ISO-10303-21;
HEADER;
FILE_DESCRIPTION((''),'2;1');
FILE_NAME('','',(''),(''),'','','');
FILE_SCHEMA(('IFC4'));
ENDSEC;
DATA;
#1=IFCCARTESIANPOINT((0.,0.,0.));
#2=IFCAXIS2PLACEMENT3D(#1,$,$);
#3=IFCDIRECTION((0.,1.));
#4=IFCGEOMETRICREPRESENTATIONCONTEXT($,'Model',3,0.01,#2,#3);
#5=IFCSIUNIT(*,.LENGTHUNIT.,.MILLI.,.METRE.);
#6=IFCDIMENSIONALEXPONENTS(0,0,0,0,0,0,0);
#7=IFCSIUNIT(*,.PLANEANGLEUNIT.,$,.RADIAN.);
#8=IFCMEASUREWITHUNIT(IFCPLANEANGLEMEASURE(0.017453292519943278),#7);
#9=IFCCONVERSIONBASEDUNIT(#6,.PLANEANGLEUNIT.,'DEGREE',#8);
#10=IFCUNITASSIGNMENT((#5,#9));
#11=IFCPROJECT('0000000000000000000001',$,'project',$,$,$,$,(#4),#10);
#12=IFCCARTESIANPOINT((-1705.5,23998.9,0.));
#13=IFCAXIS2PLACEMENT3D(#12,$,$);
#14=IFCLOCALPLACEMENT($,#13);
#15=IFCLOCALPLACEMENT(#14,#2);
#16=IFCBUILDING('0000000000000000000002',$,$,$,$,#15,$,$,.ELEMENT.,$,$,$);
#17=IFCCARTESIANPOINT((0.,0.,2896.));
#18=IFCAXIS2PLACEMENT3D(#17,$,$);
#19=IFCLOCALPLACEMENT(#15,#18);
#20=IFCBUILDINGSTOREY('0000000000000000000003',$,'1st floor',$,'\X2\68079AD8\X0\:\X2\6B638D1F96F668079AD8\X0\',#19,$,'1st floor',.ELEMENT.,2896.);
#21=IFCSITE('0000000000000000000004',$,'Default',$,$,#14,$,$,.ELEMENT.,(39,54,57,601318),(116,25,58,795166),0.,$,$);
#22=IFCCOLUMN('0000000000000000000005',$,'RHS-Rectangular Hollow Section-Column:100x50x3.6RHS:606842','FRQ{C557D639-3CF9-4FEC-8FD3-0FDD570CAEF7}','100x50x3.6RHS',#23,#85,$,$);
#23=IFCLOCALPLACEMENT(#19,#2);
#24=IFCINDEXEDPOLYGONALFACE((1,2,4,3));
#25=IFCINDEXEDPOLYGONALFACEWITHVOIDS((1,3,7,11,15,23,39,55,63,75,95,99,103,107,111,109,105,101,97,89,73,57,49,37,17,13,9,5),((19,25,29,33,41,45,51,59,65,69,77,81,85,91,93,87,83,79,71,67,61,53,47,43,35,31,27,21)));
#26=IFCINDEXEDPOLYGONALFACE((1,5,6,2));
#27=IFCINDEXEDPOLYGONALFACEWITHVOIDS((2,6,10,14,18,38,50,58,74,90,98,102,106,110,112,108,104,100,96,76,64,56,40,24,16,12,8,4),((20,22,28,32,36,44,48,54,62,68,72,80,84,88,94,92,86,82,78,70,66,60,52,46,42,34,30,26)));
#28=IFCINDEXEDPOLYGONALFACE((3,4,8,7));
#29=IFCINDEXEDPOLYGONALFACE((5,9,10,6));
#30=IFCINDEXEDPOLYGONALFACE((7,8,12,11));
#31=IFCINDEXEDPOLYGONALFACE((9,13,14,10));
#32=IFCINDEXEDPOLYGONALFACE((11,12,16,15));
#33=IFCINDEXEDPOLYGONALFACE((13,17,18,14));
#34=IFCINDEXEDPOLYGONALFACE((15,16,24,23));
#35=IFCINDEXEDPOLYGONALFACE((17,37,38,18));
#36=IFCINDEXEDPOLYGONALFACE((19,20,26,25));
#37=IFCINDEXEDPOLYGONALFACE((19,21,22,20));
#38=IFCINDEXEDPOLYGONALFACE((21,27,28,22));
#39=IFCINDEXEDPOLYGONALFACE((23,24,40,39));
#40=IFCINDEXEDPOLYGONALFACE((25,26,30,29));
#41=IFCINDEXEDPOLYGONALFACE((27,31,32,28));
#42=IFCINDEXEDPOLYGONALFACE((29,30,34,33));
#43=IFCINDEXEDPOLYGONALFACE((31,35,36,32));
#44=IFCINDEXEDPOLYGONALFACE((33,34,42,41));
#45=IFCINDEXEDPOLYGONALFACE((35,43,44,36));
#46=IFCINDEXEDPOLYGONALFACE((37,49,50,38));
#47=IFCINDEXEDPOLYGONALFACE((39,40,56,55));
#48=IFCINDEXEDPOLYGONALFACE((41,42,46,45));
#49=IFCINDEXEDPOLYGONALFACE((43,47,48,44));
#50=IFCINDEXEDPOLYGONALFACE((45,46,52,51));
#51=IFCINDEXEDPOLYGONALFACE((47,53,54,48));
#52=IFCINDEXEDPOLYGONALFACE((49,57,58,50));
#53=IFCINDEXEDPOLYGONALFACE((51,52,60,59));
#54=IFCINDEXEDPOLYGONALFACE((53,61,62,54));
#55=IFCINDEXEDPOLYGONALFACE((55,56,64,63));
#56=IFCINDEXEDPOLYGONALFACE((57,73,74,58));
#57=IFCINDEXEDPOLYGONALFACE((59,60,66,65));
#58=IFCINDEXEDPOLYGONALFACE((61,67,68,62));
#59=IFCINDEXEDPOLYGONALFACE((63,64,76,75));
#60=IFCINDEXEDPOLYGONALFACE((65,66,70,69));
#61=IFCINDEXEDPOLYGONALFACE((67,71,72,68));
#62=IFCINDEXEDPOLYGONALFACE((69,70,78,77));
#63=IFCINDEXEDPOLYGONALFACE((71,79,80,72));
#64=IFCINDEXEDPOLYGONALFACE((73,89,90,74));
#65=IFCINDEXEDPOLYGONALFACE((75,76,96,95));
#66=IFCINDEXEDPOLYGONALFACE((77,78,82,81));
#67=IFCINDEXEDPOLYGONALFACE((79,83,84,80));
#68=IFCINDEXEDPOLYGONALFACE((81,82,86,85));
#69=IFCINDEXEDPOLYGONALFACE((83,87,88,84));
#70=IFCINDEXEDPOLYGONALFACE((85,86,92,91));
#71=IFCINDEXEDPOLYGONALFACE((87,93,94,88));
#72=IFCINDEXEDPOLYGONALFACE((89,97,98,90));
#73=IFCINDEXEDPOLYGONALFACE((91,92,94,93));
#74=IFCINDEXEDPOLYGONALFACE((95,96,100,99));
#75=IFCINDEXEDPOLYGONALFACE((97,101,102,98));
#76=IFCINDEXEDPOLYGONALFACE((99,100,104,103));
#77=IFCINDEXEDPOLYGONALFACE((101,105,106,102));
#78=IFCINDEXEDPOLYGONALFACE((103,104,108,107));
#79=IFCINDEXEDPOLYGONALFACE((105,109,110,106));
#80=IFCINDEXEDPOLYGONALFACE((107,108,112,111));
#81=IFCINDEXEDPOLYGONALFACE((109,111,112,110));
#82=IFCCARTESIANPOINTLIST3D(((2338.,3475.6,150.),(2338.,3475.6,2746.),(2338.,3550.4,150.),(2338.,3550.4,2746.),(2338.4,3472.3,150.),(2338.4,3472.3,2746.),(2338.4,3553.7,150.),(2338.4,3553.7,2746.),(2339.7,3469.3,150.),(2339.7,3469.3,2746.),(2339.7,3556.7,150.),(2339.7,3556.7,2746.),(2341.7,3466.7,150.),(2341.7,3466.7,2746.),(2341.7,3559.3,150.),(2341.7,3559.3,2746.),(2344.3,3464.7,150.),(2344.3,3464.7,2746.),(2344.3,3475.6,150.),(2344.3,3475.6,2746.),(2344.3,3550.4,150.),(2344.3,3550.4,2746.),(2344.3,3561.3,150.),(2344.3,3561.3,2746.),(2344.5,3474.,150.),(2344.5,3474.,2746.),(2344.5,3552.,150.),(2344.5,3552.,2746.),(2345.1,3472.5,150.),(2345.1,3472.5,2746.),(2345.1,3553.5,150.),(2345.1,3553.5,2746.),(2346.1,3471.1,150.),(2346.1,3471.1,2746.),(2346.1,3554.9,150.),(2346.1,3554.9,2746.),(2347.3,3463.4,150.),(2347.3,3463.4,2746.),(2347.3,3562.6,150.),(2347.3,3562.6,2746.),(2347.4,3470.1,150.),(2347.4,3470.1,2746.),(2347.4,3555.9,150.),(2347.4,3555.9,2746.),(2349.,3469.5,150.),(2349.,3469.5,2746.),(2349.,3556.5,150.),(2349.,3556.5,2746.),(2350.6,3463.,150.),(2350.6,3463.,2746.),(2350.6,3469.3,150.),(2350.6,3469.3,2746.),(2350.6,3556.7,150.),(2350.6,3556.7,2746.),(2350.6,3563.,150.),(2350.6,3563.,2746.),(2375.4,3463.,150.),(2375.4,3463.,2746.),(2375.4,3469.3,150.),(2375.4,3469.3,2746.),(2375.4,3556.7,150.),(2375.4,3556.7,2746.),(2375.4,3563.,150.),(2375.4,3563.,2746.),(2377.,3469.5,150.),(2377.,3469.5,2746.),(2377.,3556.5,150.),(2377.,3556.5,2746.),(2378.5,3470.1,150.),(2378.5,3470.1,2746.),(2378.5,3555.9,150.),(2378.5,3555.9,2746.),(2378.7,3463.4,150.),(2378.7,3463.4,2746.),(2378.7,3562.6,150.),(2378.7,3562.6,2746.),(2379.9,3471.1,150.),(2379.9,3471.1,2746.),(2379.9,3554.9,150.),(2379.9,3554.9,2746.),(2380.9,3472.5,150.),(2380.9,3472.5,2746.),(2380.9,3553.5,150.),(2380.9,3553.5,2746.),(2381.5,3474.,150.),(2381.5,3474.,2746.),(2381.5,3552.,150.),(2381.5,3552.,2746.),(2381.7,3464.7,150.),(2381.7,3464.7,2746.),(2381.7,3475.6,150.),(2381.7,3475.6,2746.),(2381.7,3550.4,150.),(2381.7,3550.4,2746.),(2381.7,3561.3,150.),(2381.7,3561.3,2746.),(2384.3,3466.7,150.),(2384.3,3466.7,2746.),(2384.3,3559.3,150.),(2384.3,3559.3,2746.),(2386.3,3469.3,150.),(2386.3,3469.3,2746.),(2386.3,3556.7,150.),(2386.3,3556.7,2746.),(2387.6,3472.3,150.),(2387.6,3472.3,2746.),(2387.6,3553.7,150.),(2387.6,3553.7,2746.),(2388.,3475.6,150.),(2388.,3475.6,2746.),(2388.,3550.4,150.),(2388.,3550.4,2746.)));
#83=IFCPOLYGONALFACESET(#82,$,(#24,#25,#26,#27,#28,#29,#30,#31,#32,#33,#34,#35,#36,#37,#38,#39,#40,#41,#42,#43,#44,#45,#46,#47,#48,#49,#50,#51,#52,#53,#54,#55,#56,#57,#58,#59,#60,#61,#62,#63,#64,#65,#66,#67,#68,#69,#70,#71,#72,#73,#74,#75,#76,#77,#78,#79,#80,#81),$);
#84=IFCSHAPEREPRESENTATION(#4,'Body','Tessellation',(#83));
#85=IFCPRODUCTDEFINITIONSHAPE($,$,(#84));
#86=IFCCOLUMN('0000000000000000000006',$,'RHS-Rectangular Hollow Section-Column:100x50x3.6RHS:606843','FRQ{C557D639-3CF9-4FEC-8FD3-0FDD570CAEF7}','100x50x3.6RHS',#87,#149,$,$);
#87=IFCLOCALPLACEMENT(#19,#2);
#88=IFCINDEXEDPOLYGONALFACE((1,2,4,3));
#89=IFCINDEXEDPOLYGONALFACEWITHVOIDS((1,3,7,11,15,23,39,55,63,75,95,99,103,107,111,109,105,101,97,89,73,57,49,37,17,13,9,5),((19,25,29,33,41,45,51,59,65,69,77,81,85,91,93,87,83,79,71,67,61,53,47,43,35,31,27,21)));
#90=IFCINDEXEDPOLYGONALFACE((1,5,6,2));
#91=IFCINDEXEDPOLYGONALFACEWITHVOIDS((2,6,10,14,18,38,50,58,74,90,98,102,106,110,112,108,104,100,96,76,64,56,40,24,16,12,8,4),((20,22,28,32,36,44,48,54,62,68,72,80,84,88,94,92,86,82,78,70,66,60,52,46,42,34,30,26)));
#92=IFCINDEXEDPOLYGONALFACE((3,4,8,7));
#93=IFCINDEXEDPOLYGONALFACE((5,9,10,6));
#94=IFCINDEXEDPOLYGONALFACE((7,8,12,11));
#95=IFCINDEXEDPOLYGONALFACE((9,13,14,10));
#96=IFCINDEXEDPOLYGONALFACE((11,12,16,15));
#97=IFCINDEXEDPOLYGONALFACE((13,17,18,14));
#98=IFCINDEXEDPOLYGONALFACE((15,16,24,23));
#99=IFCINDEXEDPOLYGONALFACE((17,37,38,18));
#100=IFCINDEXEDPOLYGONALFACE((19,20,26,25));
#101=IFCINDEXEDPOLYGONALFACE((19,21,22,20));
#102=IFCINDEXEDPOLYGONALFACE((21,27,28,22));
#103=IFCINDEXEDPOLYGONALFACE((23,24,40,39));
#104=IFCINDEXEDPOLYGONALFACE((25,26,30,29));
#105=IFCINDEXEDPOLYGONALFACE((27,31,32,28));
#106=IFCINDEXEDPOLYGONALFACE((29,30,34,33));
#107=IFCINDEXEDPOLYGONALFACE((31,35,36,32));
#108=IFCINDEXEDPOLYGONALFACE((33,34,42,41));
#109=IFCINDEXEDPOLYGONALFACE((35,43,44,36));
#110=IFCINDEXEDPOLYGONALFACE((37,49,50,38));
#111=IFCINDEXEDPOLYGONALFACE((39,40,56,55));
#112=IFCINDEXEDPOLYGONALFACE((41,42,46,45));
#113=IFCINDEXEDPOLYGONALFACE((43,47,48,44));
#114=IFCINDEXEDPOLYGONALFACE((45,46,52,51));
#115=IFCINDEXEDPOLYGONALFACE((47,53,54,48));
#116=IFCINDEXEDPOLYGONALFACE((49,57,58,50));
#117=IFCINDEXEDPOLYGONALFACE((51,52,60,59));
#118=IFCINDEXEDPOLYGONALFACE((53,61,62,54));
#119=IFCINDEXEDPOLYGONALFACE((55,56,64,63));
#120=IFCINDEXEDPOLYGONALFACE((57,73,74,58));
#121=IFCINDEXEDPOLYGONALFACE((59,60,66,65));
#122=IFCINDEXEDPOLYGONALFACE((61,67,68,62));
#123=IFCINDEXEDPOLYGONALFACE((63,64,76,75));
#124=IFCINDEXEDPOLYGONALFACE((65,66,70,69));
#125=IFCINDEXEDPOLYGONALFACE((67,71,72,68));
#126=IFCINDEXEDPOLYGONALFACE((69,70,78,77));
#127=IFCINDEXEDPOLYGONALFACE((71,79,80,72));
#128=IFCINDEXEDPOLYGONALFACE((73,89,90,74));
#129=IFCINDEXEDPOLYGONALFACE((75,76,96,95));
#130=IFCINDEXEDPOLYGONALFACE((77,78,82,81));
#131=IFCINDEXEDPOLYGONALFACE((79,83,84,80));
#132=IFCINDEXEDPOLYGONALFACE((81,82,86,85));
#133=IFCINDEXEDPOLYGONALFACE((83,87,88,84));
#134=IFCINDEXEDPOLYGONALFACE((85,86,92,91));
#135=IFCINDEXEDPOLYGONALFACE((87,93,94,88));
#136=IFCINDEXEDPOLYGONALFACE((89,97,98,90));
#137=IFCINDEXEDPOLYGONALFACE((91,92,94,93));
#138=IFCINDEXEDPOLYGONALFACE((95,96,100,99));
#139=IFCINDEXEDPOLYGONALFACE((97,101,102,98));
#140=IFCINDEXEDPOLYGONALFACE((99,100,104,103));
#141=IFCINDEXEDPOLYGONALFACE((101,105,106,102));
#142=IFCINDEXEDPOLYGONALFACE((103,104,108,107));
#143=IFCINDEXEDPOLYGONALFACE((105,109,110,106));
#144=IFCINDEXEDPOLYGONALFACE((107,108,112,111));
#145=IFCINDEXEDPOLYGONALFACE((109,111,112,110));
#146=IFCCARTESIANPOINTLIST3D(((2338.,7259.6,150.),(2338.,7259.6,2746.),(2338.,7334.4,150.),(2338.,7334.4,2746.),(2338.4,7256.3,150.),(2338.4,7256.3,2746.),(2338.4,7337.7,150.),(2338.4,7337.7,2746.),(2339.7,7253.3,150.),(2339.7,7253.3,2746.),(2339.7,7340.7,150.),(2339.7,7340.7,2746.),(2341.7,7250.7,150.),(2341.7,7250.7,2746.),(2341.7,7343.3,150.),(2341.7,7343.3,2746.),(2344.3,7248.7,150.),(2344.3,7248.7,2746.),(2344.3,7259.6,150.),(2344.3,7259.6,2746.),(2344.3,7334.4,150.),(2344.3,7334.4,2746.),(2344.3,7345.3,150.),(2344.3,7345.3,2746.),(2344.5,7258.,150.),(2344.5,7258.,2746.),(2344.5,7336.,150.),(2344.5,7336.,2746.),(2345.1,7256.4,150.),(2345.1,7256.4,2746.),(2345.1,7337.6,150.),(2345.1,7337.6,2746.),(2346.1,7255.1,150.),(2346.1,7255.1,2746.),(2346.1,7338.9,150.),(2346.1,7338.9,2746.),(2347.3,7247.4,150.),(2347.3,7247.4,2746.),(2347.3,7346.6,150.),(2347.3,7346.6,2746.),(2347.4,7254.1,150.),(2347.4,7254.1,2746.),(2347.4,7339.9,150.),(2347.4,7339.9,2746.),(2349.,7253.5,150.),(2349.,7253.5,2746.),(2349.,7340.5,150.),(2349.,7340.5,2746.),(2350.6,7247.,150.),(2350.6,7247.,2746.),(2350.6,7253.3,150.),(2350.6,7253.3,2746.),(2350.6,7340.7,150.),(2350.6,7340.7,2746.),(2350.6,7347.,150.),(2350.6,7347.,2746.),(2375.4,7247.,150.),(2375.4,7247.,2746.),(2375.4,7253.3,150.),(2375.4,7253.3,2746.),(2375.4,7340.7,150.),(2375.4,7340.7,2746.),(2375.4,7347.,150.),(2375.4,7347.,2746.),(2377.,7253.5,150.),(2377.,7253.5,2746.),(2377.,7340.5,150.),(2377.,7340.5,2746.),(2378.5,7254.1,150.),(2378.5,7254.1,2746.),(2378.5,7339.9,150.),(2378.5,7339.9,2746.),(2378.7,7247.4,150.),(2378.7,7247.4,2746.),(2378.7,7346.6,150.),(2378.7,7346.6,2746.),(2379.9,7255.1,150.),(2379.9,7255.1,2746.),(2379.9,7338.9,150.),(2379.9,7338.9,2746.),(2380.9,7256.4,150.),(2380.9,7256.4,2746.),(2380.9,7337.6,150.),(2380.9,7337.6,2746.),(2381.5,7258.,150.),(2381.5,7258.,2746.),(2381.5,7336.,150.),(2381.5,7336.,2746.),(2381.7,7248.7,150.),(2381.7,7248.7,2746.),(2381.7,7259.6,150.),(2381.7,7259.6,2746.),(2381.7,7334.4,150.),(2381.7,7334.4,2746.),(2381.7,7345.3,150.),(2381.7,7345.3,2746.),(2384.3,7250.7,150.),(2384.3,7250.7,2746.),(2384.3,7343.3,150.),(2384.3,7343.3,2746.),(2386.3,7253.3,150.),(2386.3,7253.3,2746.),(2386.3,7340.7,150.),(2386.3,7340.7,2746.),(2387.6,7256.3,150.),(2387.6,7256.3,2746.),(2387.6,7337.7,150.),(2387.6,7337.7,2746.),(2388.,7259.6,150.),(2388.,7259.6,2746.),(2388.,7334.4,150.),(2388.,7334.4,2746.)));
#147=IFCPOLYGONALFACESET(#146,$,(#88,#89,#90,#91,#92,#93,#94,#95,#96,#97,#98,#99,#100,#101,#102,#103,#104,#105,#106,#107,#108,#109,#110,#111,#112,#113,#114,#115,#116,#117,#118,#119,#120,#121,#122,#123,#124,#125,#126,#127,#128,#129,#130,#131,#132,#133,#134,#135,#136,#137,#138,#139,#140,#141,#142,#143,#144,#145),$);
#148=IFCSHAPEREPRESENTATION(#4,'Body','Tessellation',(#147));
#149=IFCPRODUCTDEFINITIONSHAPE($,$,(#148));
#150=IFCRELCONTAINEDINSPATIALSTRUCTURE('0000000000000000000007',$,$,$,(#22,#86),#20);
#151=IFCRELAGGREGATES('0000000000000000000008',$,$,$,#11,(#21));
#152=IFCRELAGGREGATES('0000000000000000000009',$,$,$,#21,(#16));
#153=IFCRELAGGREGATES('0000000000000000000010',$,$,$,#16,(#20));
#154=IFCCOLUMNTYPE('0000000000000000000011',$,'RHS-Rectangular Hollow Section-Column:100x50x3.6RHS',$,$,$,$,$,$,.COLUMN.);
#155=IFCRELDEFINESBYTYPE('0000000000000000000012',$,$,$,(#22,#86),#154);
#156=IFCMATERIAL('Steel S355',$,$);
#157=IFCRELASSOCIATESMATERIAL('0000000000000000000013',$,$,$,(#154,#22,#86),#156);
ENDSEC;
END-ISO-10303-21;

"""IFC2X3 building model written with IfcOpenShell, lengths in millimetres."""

from ifc_helpers import new_model, entity, si_unit, converted_unit, direction, frame, origin, origin_2d, place, context, project, spatial, hollow_rectangle, extrude, clip, halfspace, material, type_object, element, save


model = new_model("IFC2X3")

# Units and contexts
model_context = context("Model", 3, precision=0.01, world=origin(), true_north=direction((0.0, 1.0)))
ifc_project = project(units=[si_unit("LENGTHUNIT", "METRE", prefix="MILLI"), converted_unit("PLANEANGLEUNIT", "DEGREE", entity("IfcPlaneAngleMeasure", 0.017453292519943278), si_unit("PLANEANGLEUNIT", "RADIAN"), dimensions=[0, 0, 0, 0, 0, 0, 0])], contexts=[model_context])

# Site, building, storey
site_placement = place(None, frame((-1705.5, 23998.9, 0.0)))
site = spatial("IfcSite", under=ifc_project, at=site_placement, Name="Default", CompositionType="ELEMENT", RefLatitude=(39, 54, 57, 601318), RefLongitude=(116, 25, 58, 795166), RefElevation=0.0)
building_placement = place(site_placement, origin())
building = spatial("IfcBuilding", under=site, at=building_placement, CompositionType="ELEMENT")
storey_placement = place(building_placement, frame((0.0, 0.0, 2896.0)))
storey = spatial("IfcBuildingStorey", under=building, at=storey_placement, Name="1st floor", ObjectType="标高:正负零标高", LongName="1st floor", CompositionType="ELEMENT", Elevation=2896.0)

# Columns
ifc_material_1 = material(Name="Steel S355")
column_type_1 = type_object("IfcColumnType", Name="RHS-Rectangular Hollow Section-Column:100x50x3.6RHS", PredefinedType="COLUMN", material=ifc_material_1)
column_1_placement = place(storey_placement, frame((2363.0, 3513.0, 2746.0), z_axis=(0.0, 0.0, 1.0), x_axis=(-1.0, 0.0, 0.0)))
element("IfcColumn", 1, at=column_1_placement, inside=storey, type_object=column_type_1, material=ifc_material_1, Name="RHS-Rectangular Hollow Section-Column:100x50x3.6RHS:606842", Description="FRQ{C557D639-3CF9-4FEC-8FD3-0FDD570CAEF7}", ObjectType="100x50x3.6RHS", context=model_context, shape_type="Clipping", body=[
    clip(extrude(hollow_rectangle(XDim=50.0, YDim=100.0, WallThickness=6.3, InnerFilletRadius=6.3, OuterFilletRadius=12.6, at=origin_2d()), origin(), (0.0, 0.0, -1.0), 2651.9), halfspace(frame((2363.0, 3513.0, -2596.0), z_axis=(0.0, 0.0, 1.0), x_axis=(-1.0, 0.0, 0.0)), True)),
])
column_2_placement = place(storey_placement, frame((2363.0, 7297.0, 2746.0), z_axis=(0.0, 0.0, 1.0), x_axis=(-1.0, 0.0, 0.0)))
element("IfcColumn", 2, at=column_2_placement, inside=storey, type_object=column_type_1, material=ifc_material_1, Name="RHS-Rectangular Hollow Section-Column:100x50x3.6RHS:606843", Description="FRQ{C557D639-3CF9-4FEC-8FD3-0FDD570CAEF7}", ObjectType="100x50x3.6RHS", context=model_context, shape_type="Clipping", body=[
    clip(extrude(hollow_rectangle(XDim=50.0, YDim=100.0, WallThickness=6.3, InnerFilletRadius=6.3, OuterFilletRadius=12.6, at=origin_2d()), origin(), (0.0, 0.0, -1.0), 2651.9), halfspace(frame((2363.0, 7297.0, -2596.0), z_axis=(0.0, 0.0, 1.0), x_axis=(-1.0, 0.0, 0.0)), True)),
])

save(model, "model.ifc")
